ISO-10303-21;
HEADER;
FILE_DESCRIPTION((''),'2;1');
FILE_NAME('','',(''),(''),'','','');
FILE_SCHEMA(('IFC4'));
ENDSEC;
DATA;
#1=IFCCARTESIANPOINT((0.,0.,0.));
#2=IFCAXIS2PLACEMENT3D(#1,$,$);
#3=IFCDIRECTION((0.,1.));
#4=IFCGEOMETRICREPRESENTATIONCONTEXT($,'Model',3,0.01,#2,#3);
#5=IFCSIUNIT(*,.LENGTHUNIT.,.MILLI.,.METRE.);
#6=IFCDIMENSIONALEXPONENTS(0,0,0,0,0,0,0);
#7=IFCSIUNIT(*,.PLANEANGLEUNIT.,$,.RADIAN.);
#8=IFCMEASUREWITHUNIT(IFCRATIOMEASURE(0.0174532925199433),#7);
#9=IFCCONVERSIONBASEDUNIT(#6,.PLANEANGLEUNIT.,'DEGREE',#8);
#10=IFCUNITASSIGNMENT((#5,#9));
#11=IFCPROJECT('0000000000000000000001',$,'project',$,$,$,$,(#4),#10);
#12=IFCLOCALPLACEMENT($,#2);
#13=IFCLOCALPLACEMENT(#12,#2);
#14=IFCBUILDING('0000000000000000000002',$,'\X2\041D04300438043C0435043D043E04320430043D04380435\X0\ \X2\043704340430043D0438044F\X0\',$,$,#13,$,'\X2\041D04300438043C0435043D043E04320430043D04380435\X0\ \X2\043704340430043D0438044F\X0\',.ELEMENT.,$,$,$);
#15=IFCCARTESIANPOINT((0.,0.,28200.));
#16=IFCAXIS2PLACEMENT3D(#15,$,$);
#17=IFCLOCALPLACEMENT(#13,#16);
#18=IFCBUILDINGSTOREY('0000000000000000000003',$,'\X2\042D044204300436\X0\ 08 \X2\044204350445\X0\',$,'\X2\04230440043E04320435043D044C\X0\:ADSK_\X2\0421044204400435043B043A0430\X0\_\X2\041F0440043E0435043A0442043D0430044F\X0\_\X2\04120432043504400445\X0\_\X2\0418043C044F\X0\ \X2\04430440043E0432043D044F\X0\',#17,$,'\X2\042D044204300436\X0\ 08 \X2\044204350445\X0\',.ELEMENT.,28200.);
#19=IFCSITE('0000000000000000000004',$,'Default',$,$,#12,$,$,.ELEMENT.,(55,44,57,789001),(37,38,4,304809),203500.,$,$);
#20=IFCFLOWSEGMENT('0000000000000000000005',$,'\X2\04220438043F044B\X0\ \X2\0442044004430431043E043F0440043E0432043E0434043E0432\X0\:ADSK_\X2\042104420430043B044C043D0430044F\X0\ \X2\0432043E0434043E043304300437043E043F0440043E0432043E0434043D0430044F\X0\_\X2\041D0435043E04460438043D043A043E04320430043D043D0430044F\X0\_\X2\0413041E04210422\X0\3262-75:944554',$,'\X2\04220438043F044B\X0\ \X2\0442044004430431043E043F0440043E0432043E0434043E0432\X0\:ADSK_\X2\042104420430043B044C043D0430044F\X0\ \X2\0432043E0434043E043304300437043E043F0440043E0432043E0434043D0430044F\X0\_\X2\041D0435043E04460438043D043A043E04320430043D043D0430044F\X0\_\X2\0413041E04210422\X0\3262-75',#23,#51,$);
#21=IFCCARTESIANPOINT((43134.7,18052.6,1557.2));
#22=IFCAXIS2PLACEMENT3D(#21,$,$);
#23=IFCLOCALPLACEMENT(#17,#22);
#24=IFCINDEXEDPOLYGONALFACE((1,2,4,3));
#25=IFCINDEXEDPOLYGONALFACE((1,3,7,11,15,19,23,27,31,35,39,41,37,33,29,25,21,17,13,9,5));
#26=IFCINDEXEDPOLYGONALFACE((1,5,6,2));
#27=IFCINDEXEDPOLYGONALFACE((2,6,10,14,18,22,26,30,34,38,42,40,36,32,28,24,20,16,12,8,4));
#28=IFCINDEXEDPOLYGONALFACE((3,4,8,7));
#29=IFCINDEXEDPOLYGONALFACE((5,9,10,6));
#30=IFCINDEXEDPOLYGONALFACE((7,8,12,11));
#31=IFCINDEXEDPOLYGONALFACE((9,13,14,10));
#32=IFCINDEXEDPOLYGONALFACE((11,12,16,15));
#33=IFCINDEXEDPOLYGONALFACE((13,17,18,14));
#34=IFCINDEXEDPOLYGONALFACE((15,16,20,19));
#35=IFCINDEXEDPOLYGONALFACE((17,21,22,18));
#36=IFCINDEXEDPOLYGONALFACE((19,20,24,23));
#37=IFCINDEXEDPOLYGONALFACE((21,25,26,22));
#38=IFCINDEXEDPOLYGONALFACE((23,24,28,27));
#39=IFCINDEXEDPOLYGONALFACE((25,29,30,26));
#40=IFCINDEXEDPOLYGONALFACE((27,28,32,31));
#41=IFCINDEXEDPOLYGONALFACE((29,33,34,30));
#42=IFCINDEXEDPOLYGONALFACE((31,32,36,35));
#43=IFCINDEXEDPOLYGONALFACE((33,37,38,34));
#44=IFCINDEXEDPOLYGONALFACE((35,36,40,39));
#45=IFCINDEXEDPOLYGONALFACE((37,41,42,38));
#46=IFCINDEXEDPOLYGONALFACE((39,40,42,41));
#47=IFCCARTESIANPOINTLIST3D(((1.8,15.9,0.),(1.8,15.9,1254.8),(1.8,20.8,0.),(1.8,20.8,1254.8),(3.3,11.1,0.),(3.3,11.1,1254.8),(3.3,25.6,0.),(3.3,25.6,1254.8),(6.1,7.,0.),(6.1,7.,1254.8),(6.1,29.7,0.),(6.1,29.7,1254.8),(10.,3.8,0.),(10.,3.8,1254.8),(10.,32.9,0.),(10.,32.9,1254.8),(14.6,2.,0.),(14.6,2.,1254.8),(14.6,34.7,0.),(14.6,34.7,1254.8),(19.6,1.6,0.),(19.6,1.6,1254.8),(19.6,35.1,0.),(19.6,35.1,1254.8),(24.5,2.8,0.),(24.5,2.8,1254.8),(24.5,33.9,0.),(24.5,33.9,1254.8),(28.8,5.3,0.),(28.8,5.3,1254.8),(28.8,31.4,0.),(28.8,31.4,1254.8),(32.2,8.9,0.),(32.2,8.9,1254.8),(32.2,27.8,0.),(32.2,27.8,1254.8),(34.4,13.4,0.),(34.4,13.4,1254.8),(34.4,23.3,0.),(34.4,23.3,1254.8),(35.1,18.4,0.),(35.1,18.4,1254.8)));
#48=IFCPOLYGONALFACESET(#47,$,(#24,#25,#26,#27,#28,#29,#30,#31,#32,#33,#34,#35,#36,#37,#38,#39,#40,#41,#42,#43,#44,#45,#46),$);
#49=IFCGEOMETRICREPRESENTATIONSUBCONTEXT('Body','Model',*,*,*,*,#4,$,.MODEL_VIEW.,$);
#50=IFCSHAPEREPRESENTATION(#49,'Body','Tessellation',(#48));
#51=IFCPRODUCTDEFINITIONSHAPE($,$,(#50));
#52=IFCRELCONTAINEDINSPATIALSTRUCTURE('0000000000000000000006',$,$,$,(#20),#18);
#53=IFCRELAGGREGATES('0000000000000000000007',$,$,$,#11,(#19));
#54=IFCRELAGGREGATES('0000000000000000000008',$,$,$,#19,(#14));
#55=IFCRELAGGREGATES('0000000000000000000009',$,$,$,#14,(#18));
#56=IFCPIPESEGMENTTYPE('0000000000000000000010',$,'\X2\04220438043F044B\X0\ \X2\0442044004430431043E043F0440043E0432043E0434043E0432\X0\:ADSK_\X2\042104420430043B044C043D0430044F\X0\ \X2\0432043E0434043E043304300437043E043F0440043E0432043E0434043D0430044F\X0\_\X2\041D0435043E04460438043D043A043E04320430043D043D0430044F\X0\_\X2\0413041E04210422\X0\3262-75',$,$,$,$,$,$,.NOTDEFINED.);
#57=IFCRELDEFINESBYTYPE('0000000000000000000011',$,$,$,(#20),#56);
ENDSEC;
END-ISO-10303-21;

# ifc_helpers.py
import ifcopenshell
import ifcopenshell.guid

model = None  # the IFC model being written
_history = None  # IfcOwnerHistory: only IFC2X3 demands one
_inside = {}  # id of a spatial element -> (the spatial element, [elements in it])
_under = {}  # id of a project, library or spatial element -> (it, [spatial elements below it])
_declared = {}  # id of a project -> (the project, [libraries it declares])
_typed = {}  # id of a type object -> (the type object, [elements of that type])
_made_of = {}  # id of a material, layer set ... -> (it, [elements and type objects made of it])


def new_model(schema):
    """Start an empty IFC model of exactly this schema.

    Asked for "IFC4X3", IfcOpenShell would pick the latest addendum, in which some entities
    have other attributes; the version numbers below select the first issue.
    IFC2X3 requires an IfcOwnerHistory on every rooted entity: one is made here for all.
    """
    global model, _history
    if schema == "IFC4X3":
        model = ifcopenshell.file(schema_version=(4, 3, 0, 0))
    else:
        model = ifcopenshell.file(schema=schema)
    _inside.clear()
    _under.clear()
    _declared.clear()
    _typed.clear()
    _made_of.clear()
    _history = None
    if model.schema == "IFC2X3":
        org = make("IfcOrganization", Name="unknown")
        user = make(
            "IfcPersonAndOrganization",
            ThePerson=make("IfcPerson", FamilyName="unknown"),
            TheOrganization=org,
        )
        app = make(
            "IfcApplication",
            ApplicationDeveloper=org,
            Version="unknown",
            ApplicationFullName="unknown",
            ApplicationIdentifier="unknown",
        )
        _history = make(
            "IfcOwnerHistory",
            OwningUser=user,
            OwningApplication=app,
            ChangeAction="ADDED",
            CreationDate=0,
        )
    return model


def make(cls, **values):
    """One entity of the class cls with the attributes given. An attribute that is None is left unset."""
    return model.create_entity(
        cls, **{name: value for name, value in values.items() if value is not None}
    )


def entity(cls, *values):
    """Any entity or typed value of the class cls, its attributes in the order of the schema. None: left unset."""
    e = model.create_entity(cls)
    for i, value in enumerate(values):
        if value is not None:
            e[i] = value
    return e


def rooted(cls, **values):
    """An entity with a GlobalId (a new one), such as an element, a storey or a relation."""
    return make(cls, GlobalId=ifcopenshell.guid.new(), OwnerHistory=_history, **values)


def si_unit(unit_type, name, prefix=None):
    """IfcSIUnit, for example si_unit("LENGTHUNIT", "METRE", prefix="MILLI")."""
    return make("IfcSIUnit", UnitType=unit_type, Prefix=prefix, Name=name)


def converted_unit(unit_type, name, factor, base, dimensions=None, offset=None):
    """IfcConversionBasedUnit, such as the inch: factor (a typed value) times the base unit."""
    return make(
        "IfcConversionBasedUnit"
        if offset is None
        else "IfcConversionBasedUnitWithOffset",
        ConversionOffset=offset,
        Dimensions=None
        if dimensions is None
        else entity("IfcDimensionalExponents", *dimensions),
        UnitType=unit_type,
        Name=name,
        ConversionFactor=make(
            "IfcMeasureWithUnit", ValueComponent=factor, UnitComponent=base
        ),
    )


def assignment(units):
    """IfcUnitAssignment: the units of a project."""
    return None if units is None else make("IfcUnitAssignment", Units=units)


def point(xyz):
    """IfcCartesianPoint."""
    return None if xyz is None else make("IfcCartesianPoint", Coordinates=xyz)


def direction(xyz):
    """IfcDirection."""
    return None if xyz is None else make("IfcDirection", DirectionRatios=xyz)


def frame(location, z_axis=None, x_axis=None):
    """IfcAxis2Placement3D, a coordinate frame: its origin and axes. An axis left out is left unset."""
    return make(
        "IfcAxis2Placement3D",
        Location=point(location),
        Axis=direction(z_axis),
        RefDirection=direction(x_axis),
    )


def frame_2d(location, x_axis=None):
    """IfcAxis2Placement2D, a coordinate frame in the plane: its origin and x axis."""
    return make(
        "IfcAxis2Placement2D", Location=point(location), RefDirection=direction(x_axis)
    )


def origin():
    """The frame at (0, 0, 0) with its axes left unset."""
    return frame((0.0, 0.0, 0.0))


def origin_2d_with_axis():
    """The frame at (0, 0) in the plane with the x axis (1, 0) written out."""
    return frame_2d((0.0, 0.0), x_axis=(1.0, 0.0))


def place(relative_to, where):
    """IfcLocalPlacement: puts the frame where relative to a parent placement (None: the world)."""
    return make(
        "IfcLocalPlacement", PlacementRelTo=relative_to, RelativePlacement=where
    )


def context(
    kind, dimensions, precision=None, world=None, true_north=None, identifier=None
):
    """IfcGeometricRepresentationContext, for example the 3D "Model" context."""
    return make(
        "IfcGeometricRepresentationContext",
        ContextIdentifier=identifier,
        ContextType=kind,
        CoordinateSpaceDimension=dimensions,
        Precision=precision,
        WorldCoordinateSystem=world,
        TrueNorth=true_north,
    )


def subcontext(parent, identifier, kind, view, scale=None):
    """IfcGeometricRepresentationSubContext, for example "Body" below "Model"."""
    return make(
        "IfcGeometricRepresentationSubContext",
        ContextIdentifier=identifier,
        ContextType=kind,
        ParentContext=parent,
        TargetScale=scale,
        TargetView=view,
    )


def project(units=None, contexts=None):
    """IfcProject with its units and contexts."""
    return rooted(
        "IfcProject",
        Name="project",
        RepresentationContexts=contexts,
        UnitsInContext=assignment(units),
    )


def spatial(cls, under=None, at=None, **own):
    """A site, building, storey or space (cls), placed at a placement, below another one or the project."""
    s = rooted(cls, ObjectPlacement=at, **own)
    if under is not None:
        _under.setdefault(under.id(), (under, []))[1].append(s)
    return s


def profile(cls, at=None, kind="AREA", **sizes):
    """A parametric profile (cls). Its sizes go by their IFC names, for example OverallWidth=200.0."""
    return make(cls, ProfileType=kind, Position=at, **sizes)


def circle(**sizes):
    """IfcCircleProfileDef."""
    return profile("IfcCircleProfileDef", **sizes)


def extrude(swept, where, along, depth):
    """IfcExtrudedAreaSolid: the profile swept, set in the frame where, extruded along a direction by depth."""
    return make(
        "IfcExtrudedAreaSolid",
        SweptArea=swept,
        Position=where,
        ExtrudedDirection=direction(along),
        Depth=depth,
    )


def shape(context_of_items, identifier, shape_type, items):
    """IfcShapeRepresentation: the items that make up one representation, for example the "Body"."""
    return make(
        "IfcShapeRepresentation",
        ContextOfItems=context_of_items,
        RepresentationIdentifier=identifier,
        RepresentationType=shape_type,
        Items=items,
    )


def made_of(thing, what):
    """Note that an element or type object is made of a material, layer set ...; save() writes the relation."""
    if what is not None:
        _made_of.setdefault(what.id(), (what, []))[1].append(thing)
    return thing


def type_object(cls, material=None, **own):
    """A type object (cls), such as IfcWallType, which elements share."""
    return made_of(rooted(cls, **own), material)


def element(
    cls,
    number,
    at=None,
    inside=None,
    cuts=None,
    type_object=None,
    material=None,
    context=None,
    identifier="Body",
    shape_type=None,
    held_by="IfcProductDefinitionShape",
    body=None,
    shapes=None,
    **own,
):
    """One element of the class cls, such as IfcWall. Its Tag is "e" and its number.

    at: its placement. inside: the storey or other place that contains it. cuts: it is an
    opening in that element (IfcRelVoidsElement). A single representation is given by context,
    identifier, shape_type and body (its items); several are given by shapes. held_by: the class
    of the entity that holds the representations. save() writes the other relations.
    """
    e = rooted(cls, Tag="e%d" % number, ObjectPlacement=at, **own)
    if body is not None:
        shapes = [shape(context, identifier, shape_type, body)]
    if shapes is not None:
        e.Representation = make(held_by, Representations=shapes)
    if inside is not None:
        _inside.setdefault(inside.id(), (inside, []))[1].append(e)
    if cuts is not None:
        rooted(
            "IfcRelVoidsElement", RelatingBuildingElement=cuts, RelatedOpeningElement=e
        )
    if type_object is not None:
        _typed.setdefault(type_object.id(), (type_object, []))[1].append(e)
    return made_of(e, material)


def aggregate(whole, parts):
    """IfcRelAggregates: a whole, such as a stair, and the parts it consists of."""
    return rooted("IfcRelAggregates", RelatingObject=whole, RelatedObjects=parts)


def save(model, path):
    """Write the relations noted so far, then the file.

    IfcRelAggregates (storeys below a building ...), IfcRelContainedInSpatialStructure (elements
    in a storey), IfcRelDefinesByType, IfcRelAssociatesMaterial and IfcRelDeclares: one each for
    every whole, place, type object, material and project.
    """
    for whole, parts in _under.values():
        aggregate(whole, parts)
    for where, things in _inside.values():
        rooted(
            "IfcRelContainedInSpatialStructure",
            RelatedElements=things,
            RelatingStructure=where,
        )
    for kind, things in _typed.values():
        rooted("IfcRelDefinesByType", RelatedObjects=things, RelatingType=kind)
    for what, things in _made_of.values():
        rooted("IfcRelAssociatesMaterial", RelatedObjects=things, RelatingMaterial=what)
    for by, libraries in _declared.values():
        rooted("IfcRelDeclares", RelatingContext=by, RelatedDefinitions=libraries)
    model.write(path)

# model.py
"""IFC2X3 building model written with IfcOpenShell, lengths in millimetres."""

from ifc_helpers import new_model, entity, si_unit, converted_unit, direction, frame, origin, origin_2d_with_axis, place, context, subcontext, project, spatial, circle, extrude, type_object, element, save


model = new_model("IFC2X3")

# Units and contexts
model_context = context("Model", 3, precision=0.01, world=origin(), true_north=direction((0.0, 1.0)))
body_context = subcontext(model_context, "Body", "Model", "MODEL_VIEW")
ifc_project = project(units=[si_unit("LENGTHUNIT", "METRE", prefix="MILLI"), converted_unit("PLANEANGLEUNIT", "DEGREE", entity("IfcRatioMeasure", 0.0174532925199433), si_unit("PLANEANGLEUNIT", "RADIAN"), dimensions=[0, 0, 0, 0, 0, 0, 0])], contexts=[model_context])

# Site, building, storey
site_placement = place(None, origin())
site = spatial("IfcSite", under=ifc_project, at=site_placement, Name="Default", CompositionType="ELEMENT", RefLatitude=(55, 44, 57, 789001), RefLongitude=(37, 38, 4, 304809), RefElevation=203500.0)
building_placement = place(site_placement, origin())
building = spatial("IfcBuilding", under=site, at=building_placement, Name="Наименование здания", LongName="Наименование здания", CompositionType="ELEMENT")
storey_placement = place(building_placement, frame((0.0, 0.0, 28200.0)))
storey = spatial("IfcBuildingStorey", under=building, at=storey_placement, Name="Этаж 08 тех", ObjectType="Уровень:ADSK_Стрелка_Проектная_Вверх_Имя уровня", LongName="Этаж 08 тех", CompositionType="ELEMENT", Elevation=28200.0)

# Flow segment
pipe_segment_type = type_object("IfcPipeSegmentType", Name="Типы трубопроводов:ADSK_Стальная водогазопроводная_Неоцинкованная_ГОСТ3262-75", PredefinedType="NOTDEFINED")
flow_segment_1_placement = place(storey_placement, frame((43134.7, 18052.6, 1557.2)))
element("IfcFlowSegment", 1, at=flow_segment_1_placement, inside=storey, type_object=pipe_segment_type, Name="Типы трубопроводов:ADSK_Стальная водогазопроводная_Неоцинкованная_ГОСТ3262-75:944554", ObjectType="Типы трубопроводов:ADSK_Стальная водогазопроводная_Неоцинкованная_ГОСТ3262-75", context=body_context, shape_type="SweptSolid", body=[
    extrude(circle(Radius=16.8, at=origin_2d_with_axis()), frame((18.4, 18.4, 0.0)), (0.0, 0.0, 1.0), 1254.8),
])

save(model, "model.ifc")
